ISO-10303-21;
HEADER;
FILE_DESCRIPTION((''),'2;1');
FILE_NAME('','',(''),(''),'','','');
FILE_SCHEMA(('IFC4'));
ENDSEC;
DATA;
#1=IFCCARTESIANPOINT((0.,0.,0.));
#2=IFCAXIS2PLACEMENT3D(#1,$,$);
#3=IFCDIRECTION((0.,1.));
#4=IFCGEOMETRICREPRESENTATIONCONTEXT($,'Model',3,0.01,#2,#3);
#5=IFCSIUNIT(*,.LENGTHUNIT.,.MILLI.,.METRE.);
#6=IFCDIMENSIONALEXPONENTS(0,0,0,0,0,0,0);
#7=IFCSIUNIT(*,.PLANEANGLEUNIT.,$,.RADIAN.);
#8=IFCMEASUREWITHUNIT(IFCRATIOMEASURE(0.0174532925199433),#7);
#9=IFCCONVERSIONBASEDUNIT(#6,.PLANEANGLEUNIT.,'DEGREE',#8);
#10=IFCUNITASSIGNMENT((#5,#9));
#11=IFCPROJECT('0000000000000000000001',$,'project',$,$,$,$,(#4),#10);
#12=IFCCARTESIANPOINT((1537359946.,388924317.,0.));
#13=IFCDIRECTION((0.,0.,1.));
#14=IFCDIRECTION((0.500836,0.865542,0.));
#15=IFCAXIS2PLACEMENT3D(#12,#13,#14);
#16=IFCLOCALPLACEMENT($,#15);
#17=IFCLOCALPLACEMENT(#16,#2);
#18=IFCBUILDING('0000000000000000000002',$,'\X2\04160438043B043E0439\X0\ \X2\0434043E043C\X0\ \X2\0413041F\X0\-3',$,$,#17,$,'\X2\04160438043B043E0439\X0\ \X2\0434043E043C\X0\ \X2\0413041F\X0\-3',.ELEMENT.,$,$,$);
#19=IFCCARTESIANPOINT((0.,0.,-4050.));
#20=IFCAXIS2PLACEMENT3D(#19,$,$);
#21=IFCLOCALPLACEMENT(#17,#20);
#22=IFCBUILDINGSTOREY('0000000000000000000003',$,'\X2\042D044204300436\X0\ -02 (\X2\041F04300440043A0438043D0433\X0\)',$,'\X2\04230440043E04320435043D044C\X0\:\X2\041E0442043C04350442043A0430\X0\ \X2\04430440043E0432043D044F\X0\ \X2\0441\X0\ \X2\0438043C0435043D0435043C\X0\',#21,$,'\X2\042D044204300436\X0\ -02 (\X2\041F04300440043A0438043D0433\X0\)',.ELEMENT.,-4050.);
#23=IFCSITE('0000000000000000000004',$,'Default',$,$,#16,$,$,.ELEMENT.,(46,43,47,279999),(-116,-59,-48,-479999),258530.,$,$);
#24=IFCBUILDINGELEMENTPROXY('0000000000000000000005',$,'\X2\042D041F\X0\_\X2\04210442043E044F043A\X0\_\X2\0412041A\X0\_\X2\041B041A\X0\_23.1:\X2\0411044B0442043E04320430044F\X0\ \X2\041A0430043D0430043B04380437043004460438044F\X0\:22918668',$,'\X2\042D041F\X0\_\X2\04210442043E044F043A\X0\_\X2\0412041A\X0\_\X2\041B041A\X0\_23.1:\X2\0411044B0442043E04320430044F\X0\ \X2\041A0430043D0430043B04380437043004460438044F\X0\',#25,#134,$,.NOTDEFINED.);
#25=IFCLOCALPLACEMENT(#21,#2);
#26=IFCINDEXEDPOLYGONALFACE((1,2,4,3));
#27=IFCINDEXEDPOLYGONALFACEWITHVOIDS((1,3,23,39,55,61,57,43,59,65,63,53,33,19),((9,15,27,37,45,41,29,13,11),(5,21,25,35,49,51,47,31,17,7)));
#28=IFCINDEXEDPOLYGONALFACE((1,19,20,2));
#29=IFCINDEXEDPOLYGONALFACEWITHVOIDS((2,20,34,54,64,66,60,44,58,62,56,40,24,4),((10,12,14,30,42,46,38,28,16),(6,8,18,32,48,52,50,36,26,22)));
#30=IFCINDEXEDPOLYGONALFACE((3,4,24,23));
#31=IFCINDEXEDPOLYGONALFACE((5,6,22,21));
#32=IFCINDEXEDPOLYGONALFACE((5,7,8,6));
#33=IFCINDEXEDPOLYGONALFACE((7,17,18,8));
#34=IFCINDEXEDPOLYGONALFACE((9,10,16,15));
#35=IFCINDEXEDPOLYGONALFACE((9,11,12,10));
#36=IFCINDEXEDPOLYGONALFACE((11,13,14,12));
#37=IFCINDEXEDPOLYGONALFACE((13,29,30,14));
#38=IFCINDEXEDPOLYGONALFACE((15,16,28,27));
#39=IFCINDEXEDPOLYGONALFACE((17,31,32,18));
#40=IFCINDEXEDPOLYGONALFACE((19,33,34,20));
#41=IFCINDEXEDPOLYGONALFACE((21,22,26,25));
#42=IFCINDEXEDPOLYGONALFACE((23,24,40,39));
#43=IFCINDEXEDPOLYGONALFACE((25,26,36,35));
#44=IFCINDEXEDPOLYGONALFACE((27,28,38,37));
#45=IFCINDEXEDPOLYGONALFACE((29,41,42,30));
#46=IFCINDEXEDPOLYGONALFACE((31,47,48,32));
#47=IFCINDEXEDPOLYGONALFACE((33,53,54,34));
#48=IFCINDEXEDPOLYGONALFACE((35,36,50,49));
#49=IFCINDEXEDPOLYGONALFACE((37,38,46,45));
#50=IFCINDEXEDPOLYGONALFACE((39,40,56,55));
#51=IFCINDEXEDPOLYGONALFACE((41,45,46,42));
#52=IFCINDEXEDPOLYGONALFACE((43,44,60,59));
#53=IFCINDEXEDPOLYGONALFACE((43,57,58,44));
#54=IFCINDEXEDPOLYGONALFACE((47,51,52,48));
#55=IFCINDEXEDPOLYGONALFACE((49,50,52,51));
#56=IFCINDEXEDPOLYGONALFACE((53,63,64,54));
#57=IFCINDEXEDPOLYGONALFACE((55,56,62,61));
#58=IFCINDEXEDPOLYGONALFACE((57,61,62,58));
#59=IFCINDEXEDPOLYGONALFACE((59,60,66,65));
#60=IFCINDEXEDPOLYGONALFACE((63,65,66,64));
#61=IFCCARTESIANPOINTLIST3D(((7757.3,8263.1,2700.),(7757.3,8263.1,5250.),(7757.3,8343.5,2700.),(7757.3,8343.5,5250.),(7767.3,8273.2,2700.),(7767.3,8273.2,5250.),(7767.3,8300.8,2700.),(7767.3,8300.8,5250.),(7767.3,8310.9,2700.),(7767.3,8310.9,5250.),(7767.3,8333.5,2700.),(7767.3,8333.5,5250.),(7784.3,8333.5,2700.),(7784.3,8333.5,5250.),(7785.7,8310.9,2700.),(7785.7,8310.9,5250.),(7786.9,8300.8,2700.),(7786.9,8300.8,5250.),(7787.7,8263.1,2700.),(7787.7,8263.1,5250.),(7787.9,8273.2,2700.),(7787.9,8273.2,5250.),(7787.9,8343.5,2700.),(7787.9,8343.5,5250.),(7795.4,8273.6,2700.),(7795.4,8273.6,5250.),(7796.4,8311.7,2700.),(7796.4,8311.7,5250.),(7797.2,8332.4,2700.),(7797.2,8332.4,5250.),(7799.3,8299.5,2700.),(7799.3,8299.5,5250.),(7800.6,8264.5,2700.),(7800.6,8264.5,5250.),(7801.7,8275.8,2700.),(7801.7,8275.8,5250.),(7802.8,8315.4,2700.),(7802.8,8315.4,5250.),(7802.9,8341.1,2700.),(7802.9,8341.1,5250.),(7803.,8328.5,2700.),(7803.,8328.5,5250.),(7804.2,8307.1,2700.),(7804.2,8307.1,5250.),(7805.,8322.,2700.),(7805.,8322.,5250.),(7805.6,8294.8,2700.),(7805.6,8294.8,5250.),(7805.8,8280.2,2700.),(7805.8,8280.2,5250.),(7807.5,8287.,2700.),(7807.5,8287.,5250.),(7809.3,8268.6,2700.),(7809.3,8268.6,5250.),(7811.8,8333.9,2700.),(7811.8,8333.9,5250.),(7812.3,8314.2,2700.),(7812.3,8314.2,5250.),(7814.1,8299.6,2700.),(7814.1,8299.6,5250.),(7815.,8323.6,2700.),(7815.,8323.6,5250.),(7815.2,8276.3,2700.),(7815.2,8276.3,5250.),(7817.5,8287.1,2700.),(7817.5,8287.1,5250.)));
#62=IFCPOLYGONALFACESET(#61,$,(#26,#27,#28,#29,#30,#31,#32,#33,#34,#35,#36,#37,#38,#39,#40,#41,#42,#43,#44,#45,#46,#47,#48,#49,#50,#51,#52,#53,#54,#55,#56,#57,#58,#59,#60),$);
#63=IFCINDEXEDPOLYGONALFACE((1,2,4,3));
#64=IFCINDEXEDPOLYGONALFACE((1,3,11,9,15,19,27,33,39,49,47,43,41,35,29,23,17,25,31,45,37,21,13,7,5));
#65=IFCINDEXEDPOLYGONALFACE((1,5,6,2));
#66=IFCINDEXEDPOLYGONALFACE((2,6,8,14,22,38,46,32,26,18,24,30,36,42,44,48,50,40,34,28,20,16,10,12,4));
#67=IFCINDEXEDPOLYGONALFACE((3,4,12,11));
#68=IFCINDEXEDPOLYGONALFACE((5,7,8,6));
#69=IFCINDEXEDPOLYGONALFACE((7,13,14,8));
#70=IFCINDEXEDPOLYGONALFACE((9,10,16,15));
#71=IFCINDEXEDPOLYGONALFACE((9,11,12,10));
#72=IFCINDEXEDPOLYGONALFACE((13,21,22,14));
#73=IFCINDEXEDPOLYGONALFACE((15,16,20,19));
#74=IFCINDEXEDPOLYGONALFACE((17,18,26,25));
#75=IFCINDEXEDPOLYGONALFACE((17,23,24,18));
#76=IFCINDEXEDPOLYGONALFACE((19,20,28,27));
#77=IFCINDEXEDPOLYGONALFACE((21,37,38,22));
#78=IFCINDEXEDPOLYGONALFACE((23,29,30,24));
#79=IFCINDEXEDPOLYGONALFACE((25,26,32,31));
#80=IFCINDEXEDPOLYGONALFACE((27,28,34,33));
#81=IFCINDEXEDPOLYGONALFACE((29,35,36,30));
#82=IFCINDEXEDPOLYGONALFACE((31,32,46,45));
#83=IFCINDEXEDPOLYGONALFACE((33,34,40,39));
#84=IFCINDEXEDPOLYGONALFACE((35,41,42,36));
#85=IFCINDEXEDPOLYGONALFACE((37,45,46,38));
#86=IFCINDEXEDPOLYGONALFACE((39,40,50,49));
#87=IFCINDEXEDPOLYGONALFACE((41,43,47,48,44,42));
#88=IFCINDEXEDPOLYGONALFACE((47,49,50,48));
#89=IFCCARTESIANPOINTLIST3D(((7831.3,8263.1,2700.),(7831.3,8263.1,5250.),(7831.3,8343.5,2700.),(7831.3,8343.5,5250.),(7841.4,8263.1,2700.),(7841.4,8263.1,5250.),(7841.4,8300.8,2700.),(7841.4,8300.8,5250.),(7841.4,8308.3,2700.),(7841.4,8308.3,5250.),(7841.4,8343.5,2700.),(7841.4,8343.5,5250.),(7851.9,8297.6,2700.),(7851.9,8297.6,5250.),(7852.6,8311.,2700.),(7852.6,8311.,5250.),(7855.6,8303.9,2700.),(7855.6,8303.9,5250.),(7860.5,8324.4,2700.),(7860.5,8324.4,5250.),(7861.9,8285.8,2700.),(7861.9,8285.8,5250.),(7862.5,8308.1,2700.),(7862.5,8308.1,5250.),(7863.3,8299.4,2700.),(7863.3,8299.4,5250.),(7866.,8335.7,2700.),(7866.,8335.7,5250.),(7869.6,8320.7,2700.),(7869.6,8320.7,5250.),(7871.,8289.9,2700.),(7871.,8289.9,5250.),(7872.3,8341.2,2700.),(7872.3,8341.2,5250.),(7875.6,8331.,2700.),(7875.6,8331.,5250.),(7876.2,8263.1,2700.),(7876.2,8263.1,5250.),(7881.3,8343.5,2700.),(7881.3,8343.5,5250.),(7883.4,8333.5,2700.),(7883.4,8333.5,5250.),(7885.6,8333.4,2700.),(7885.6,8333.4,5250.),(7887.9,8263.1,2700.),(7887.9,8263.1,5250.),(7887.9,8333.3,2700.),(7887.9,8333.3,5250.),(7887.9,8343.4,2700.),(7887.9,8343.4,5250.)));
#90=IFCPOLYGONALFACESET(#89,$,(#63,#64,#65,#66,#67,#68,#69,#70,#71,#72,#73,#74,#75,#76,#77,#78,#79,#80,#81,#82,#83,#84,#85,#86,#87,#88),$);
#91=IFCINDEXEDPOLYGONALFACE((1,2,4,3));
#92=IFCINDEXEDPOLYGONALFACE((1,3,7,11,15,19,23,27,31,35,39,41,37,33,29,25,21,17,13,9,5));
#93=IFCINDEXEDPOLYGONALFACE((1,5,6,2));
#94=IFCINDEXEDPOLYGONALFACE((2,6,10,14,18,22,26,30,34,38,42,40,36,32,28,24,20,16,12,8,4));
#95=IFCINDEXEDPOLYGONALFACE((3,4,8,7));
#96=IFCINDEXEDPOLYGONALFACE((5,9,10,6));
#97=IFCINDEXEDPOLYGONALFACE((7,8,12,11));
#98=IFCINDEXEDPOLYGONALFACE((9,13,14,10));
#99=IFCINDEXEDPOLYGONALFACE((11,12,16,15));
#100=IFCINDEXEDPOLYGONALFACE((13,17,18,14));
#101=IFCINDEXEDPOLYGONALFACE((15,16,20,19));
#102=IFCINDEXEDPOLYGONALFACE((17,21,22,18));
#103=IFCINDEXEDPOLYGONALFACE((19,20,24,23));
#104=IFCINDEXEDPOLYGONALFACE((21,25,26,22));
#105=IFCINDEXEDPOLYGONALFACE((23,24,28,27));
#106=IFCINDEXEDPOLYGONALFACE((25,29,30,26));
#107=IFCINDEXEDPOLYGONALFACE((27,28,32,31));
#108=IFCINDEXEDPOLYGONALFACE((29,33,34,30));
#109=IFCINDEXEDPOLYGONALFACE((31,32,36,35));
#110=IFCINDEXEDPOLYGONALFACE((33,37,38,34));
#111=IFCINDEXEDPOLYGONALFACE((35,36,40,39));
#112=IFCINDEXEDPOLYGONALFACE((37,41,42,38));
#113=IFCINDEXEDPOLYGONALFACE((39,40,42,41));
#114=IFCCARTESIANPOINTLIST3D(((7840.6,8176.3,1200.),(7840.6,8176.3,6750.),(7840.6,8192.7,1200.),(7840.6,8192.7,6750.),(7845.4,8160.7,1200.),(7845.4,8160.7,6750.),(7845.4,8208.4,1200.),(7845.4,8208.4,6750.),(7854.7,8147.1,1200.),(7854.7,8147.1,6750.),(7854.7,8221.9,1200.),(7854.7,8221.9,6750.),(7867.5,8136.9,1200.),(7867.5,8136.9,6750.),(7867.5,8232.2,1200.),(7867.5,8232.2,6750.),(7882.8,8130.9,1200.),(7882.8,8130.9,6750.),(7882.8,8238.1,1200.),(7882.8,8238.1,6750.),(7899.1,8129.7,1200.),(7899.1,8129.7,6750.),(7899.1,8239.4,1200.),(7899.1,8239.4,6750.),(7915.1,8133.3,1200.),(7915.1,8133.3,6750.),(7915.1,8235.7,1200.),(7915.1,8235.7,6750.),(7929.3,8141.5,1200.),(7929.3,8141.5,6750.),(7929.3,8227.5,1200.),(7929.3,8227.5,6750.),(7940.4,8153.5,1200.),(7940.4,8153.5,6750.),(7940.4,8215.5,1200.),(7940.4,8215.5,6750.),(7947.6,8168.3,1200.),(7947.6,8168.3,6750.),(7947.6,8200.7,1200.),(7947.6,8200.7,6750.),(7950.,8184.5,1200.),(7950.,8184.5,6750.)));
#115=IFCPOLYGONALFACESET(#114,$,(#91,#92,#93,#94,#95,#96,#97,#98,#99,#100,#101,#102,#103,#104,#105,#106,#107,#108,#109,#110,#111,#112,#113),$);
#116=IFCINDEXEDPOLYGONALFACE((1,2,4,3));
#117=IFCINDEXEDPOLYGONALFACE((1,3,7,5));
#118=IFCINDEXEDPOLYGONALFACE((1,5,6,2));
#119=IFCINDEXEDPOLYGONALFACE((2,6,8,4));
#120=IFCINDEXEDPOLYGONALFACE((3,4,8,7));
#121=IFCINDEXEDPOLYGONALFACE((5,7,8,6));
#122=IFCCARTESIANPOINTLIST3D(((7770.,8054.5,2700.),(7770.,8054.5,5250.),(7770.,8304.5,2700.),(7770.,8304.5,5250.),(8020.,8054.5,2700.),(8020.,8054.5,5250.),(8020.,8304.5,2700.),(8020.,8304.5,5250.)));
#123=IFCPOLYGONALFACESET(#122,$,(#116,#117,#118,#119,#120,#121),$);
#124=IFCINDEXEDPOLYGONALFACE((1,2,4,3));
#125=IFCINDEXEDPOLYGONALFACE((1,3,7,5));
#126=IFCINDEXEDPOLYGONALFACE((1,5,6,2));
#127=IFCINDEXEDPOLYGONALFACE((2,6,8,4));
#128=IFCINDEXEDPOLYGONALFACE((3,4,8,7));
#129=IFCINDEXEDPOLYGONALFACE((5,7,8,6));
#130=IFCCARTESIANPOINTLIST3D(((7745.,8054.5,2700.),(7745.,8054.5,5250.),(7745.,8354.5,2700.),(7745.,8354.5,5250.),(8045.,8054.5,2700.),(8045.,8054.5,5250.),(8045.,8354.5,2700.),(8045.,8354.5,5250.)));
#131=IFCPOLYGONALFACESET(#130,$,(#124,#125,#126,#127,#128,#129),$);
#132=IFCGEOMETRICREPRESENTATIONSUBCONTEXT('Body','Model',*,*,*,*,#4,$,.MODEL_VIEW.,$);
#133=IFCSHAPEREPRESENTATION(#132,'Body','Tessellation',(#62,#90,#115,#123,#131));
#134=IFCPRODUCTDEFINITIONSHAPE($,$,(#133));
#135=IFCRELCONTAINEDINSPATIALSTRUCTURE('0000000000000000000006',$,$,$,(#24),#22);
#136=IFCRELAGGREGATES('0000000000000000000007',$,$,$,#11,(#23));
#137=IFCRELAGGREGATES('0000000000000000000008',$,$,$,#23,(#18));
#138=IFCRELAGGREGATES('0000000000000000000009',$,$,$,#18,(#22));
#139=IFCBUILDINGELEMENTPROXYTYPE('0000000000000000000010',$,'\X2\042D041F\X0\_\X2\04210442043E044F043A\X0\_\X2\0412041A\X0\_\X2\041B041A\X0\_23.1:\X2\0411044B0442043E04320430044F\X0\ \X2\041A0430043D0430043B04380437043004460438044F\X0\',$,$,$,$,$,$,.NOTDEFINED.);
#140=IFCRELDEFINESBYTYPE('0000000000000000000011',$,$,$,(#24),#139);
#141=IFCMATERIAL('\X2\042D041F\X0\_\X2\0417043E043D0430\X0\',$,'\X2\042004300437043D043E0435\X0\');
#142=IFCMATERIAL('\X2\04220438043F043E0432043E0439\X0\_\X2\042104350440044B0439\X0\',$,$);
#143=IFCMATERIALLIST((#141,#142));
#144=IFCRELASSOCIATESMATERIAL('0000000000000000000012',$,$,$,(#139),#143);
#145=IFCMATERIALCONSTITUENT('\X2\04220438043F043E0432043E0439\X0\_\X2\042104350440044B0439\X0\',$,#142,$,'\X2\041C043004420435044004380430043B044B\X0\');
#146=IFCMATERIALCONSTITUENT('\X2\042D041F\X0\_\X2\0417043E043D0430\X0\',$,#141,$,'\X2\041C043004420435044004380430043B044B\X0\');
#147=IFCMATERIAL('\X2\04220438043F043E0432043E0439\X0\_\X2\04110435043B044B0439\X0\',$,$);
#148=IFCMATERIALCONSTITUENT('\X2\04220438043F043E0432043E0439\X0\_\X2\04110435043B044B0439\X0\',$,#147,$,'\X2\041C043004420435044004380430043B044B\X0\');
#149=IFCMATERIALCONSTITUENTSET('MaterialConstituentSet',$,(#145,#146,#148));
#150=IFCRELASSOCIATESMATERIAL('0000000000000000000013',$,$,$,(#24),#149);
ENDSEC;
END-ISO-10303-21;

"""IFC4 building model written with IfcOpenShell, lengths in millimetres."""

from ifc_helpers import new_model, entity, si_unit, converted_unit, direction, frame, frame_2d, origin, place, context, subcontext, project, spatial, polyline, rectangle, circle, outline, extrude, source, transform, mapped, material, material_list, constituent, constituent_set, type_object, type_shapes, element, save


model = new_model("IFC4")

# Units and contexts
model_context = context("Model", 3, precision=0.01, world=origin(), true_north=direction((0.0, 1.0)))
body_context = subcontext(model_context, "Body", "Model", "MODEL_VIEW")
ifc_project = project(units=[si_unit("LENGTHUNIT", "METRE", prefix="MILLI"), converted_unit("PLANEANGLEUNIT", "DEGREE", entity("IfcRatioMeasure", 0.0174532925199433), si_unit("PLANEANGLEUNIT", "RADIAN"), dimensions=[0, 0, 0, 0, 0, 0, 0])], contexts=[model_context])

# Site, building, storey
site_placement = place(None, frame((1537359946.0, 388924317.0, 0.0), z_axis=(0.0, 0.0, 1.0), x_axis=(0.500836, 0.865542, 0.0)))
site = spatial("IfcSite", under=ifc_project, at=site_placement, Name="Default", CompositionType="ELEMENT", RefLatitude=(46, 43, 47, 279999), RefLongitude=(-116, -59, -48, -479999), RefElevation=258530.0)
building_placement = place(site_placement, origin())
building = spatial("IfcBuilding", under=site, at=building_placement, Name="Жилой дом ГП-3", LongName="Жилой дом ГП-3", CompositionType="ELEMENT")
storey_placement = place(building_placement, frame((0.0, 0.0, -4050.0)))
storey = spatial("IfcBuildingStorey", under=building, at=storey_placement, Name="Этаж -02 (Паркинг)", ObjectType="Уровень:Отметка уровня с именем", LongName="Этаж -02 (Паркинг)", CompositionType="ELEMENT", Elevation=-4050.0)

# Building element proxy
ifc_material_1 = material(Name="ЭП_Зона", Category="Разное")
ifc_material_2 = material(Name="Типовой_Белый")
ifc_material_3 = material(Name="Типовой_Серый")
ifc_constituent_1 = constituent(ifc_material_3, Name="Типовой_Серый", Category="Материалы")
ifc_constituent_2 = constituent(ifc_material_1, Name="ЭП_Зона", Category="Материалы")
ifc_constituent_3 = constituent(ifc_material_2, Name="Типовой_Белый", Category="Материалы")
ifc_constituent_set_1 = constituent_set(constituents=[ifc_constituent_1, ifc_constituent_2, ifc_constituent_3], Name="MaterialConstituentSet")
ifc_material_list_1 = material_list([ifc_material_1, ifc_material_3])
building_element_proxy_type_1 = type_object("IfcBuildingElementProxyType", Name="ЭП_Стояк_ВК_ЛК_23.1:Бытовая Канализация", PredefinedType="NOTDEFINED", material=ifc_material_list_1)
shared_shape_1 = source(origin(), body_context, "Body", "SweptSolid", [
    extrude(outline(polyline([(-42.2, -39.0), (-11.8, -39.0), (1.1, -37.6), (9.8, -33.5), (15.7, -25.8), (18.0, -15.0), (14.6, -2.5), (4.7, 5.0), (12.8, 12.1), (15.5, 21.5), (12.3, 31.8), (3.4, 39.0), (-11.6, 41.4), (-42.2, 41.4), (-42.2, -39.0)]), holes=[polyline([(-32.2, 8.8), (-32.2, 31.4), (-15.2, 31.4), (-2.3, 30.3), (3.5, 26.4), (5.5, 19.9), (3.3, 13.3), (-3.1, 9.6), (-13.9, 8.8), (-32.2, 8.8)]), polyline([(-32.2, -28.9), (-32.2, -1.3), (-12.6, -1.3), (-0.2, -2.6), (6.1, -7.3), (8.0, -15.1), (6.3, -21.9), (2.2, -26.3), (-4.1, -28.5), (-11.6, -28.9), (-32.2, -28.9)])]), frame((54.5, -52.4, -1350.0)), (0.0, 0.0, 1.0), 2550.0),
    extrude(outline(polyline([(-32.1, -31.9), (48.3, -31.9), (48.3, -21.8), (10.6, -21.8), (13.8, -11.4), (25.6, -1.3), (48.3, 13.0), (48.3, 24.6), (21.4, 7.7), (12.0, 0.1), (7.4, -7.7), (3.3, -0.7), (-9.3, 6.4), (-19.7, 12.3), (-22.1, 20.2), (-22.0, 22.4), (-22.0, 24.6), (-32.0, 24.6), (-32.1, 18.0), (-29.9, 9.0), (-24.3, 2.8), (-13.1, -2.8), (0.4, -10.6), (3.0, -21.8), (-32.1, -21.8), (-32.1, -31.9)])), frame((118.2, -43.1, -1350.0), z_axis=(0.0, 0.0, 1.0), x_axis=(0.0, -1.0, 0.0)), (0.0, 0.0, 1.0), 2550.0),
    extrude(circle(Radius=55.0, at=frame_2d((0.0, 0.0), x_axis=(1.0, 0.0))), frame((150.0, -170.0, -2850.0)), (0.0, 0.0, 1.0), 5550.0),
    extrude(rectangle(XDim=250.0, YDim=250.0, at=frame_2d((0.0, 0.0), x_axis=(1.0, 0.0))), frame((150.0, -175.0, -1350.0)), (0.0, 0.0, 1.0), 2550.0),
    extrude(rectangle(XDim=300.0, YDim=300.0, at=frame_2d((0.0, 0.0), x_axis=(1.0, 0.0))), frame((150.0, -150.0, -1350.0)), (0.0, 0.0, 1.0), 2550.0),
])
type_shapes(building_element_proxy_type_1, [shared_shape_1])
proxy_1_placement = place(storey_placement, frame((7745.0, 8354.5, 4050.0)))
element("IfcBuildingElementProxy", 1, at=proxy_1_placement, inside=storey, type_object=building_element_proxy_type_1, material=ifc_constituent_set_1, Name="ЭП_Стояк_ВК_ЛК_23.1:Бытовая Канализация:22918668", ObjectType="ЭП_Стояк_ВК_ЛК_23.1:Бытовая Канализация", PredefinedType="NOTDEFINED", context=body_context, shape_type="MappedRepresentation", body=[
    mapped(shared_shape_1, transform((0.0, 0.0, 0.0), scale=1.0)),
])

save(model, "model.ifc")
